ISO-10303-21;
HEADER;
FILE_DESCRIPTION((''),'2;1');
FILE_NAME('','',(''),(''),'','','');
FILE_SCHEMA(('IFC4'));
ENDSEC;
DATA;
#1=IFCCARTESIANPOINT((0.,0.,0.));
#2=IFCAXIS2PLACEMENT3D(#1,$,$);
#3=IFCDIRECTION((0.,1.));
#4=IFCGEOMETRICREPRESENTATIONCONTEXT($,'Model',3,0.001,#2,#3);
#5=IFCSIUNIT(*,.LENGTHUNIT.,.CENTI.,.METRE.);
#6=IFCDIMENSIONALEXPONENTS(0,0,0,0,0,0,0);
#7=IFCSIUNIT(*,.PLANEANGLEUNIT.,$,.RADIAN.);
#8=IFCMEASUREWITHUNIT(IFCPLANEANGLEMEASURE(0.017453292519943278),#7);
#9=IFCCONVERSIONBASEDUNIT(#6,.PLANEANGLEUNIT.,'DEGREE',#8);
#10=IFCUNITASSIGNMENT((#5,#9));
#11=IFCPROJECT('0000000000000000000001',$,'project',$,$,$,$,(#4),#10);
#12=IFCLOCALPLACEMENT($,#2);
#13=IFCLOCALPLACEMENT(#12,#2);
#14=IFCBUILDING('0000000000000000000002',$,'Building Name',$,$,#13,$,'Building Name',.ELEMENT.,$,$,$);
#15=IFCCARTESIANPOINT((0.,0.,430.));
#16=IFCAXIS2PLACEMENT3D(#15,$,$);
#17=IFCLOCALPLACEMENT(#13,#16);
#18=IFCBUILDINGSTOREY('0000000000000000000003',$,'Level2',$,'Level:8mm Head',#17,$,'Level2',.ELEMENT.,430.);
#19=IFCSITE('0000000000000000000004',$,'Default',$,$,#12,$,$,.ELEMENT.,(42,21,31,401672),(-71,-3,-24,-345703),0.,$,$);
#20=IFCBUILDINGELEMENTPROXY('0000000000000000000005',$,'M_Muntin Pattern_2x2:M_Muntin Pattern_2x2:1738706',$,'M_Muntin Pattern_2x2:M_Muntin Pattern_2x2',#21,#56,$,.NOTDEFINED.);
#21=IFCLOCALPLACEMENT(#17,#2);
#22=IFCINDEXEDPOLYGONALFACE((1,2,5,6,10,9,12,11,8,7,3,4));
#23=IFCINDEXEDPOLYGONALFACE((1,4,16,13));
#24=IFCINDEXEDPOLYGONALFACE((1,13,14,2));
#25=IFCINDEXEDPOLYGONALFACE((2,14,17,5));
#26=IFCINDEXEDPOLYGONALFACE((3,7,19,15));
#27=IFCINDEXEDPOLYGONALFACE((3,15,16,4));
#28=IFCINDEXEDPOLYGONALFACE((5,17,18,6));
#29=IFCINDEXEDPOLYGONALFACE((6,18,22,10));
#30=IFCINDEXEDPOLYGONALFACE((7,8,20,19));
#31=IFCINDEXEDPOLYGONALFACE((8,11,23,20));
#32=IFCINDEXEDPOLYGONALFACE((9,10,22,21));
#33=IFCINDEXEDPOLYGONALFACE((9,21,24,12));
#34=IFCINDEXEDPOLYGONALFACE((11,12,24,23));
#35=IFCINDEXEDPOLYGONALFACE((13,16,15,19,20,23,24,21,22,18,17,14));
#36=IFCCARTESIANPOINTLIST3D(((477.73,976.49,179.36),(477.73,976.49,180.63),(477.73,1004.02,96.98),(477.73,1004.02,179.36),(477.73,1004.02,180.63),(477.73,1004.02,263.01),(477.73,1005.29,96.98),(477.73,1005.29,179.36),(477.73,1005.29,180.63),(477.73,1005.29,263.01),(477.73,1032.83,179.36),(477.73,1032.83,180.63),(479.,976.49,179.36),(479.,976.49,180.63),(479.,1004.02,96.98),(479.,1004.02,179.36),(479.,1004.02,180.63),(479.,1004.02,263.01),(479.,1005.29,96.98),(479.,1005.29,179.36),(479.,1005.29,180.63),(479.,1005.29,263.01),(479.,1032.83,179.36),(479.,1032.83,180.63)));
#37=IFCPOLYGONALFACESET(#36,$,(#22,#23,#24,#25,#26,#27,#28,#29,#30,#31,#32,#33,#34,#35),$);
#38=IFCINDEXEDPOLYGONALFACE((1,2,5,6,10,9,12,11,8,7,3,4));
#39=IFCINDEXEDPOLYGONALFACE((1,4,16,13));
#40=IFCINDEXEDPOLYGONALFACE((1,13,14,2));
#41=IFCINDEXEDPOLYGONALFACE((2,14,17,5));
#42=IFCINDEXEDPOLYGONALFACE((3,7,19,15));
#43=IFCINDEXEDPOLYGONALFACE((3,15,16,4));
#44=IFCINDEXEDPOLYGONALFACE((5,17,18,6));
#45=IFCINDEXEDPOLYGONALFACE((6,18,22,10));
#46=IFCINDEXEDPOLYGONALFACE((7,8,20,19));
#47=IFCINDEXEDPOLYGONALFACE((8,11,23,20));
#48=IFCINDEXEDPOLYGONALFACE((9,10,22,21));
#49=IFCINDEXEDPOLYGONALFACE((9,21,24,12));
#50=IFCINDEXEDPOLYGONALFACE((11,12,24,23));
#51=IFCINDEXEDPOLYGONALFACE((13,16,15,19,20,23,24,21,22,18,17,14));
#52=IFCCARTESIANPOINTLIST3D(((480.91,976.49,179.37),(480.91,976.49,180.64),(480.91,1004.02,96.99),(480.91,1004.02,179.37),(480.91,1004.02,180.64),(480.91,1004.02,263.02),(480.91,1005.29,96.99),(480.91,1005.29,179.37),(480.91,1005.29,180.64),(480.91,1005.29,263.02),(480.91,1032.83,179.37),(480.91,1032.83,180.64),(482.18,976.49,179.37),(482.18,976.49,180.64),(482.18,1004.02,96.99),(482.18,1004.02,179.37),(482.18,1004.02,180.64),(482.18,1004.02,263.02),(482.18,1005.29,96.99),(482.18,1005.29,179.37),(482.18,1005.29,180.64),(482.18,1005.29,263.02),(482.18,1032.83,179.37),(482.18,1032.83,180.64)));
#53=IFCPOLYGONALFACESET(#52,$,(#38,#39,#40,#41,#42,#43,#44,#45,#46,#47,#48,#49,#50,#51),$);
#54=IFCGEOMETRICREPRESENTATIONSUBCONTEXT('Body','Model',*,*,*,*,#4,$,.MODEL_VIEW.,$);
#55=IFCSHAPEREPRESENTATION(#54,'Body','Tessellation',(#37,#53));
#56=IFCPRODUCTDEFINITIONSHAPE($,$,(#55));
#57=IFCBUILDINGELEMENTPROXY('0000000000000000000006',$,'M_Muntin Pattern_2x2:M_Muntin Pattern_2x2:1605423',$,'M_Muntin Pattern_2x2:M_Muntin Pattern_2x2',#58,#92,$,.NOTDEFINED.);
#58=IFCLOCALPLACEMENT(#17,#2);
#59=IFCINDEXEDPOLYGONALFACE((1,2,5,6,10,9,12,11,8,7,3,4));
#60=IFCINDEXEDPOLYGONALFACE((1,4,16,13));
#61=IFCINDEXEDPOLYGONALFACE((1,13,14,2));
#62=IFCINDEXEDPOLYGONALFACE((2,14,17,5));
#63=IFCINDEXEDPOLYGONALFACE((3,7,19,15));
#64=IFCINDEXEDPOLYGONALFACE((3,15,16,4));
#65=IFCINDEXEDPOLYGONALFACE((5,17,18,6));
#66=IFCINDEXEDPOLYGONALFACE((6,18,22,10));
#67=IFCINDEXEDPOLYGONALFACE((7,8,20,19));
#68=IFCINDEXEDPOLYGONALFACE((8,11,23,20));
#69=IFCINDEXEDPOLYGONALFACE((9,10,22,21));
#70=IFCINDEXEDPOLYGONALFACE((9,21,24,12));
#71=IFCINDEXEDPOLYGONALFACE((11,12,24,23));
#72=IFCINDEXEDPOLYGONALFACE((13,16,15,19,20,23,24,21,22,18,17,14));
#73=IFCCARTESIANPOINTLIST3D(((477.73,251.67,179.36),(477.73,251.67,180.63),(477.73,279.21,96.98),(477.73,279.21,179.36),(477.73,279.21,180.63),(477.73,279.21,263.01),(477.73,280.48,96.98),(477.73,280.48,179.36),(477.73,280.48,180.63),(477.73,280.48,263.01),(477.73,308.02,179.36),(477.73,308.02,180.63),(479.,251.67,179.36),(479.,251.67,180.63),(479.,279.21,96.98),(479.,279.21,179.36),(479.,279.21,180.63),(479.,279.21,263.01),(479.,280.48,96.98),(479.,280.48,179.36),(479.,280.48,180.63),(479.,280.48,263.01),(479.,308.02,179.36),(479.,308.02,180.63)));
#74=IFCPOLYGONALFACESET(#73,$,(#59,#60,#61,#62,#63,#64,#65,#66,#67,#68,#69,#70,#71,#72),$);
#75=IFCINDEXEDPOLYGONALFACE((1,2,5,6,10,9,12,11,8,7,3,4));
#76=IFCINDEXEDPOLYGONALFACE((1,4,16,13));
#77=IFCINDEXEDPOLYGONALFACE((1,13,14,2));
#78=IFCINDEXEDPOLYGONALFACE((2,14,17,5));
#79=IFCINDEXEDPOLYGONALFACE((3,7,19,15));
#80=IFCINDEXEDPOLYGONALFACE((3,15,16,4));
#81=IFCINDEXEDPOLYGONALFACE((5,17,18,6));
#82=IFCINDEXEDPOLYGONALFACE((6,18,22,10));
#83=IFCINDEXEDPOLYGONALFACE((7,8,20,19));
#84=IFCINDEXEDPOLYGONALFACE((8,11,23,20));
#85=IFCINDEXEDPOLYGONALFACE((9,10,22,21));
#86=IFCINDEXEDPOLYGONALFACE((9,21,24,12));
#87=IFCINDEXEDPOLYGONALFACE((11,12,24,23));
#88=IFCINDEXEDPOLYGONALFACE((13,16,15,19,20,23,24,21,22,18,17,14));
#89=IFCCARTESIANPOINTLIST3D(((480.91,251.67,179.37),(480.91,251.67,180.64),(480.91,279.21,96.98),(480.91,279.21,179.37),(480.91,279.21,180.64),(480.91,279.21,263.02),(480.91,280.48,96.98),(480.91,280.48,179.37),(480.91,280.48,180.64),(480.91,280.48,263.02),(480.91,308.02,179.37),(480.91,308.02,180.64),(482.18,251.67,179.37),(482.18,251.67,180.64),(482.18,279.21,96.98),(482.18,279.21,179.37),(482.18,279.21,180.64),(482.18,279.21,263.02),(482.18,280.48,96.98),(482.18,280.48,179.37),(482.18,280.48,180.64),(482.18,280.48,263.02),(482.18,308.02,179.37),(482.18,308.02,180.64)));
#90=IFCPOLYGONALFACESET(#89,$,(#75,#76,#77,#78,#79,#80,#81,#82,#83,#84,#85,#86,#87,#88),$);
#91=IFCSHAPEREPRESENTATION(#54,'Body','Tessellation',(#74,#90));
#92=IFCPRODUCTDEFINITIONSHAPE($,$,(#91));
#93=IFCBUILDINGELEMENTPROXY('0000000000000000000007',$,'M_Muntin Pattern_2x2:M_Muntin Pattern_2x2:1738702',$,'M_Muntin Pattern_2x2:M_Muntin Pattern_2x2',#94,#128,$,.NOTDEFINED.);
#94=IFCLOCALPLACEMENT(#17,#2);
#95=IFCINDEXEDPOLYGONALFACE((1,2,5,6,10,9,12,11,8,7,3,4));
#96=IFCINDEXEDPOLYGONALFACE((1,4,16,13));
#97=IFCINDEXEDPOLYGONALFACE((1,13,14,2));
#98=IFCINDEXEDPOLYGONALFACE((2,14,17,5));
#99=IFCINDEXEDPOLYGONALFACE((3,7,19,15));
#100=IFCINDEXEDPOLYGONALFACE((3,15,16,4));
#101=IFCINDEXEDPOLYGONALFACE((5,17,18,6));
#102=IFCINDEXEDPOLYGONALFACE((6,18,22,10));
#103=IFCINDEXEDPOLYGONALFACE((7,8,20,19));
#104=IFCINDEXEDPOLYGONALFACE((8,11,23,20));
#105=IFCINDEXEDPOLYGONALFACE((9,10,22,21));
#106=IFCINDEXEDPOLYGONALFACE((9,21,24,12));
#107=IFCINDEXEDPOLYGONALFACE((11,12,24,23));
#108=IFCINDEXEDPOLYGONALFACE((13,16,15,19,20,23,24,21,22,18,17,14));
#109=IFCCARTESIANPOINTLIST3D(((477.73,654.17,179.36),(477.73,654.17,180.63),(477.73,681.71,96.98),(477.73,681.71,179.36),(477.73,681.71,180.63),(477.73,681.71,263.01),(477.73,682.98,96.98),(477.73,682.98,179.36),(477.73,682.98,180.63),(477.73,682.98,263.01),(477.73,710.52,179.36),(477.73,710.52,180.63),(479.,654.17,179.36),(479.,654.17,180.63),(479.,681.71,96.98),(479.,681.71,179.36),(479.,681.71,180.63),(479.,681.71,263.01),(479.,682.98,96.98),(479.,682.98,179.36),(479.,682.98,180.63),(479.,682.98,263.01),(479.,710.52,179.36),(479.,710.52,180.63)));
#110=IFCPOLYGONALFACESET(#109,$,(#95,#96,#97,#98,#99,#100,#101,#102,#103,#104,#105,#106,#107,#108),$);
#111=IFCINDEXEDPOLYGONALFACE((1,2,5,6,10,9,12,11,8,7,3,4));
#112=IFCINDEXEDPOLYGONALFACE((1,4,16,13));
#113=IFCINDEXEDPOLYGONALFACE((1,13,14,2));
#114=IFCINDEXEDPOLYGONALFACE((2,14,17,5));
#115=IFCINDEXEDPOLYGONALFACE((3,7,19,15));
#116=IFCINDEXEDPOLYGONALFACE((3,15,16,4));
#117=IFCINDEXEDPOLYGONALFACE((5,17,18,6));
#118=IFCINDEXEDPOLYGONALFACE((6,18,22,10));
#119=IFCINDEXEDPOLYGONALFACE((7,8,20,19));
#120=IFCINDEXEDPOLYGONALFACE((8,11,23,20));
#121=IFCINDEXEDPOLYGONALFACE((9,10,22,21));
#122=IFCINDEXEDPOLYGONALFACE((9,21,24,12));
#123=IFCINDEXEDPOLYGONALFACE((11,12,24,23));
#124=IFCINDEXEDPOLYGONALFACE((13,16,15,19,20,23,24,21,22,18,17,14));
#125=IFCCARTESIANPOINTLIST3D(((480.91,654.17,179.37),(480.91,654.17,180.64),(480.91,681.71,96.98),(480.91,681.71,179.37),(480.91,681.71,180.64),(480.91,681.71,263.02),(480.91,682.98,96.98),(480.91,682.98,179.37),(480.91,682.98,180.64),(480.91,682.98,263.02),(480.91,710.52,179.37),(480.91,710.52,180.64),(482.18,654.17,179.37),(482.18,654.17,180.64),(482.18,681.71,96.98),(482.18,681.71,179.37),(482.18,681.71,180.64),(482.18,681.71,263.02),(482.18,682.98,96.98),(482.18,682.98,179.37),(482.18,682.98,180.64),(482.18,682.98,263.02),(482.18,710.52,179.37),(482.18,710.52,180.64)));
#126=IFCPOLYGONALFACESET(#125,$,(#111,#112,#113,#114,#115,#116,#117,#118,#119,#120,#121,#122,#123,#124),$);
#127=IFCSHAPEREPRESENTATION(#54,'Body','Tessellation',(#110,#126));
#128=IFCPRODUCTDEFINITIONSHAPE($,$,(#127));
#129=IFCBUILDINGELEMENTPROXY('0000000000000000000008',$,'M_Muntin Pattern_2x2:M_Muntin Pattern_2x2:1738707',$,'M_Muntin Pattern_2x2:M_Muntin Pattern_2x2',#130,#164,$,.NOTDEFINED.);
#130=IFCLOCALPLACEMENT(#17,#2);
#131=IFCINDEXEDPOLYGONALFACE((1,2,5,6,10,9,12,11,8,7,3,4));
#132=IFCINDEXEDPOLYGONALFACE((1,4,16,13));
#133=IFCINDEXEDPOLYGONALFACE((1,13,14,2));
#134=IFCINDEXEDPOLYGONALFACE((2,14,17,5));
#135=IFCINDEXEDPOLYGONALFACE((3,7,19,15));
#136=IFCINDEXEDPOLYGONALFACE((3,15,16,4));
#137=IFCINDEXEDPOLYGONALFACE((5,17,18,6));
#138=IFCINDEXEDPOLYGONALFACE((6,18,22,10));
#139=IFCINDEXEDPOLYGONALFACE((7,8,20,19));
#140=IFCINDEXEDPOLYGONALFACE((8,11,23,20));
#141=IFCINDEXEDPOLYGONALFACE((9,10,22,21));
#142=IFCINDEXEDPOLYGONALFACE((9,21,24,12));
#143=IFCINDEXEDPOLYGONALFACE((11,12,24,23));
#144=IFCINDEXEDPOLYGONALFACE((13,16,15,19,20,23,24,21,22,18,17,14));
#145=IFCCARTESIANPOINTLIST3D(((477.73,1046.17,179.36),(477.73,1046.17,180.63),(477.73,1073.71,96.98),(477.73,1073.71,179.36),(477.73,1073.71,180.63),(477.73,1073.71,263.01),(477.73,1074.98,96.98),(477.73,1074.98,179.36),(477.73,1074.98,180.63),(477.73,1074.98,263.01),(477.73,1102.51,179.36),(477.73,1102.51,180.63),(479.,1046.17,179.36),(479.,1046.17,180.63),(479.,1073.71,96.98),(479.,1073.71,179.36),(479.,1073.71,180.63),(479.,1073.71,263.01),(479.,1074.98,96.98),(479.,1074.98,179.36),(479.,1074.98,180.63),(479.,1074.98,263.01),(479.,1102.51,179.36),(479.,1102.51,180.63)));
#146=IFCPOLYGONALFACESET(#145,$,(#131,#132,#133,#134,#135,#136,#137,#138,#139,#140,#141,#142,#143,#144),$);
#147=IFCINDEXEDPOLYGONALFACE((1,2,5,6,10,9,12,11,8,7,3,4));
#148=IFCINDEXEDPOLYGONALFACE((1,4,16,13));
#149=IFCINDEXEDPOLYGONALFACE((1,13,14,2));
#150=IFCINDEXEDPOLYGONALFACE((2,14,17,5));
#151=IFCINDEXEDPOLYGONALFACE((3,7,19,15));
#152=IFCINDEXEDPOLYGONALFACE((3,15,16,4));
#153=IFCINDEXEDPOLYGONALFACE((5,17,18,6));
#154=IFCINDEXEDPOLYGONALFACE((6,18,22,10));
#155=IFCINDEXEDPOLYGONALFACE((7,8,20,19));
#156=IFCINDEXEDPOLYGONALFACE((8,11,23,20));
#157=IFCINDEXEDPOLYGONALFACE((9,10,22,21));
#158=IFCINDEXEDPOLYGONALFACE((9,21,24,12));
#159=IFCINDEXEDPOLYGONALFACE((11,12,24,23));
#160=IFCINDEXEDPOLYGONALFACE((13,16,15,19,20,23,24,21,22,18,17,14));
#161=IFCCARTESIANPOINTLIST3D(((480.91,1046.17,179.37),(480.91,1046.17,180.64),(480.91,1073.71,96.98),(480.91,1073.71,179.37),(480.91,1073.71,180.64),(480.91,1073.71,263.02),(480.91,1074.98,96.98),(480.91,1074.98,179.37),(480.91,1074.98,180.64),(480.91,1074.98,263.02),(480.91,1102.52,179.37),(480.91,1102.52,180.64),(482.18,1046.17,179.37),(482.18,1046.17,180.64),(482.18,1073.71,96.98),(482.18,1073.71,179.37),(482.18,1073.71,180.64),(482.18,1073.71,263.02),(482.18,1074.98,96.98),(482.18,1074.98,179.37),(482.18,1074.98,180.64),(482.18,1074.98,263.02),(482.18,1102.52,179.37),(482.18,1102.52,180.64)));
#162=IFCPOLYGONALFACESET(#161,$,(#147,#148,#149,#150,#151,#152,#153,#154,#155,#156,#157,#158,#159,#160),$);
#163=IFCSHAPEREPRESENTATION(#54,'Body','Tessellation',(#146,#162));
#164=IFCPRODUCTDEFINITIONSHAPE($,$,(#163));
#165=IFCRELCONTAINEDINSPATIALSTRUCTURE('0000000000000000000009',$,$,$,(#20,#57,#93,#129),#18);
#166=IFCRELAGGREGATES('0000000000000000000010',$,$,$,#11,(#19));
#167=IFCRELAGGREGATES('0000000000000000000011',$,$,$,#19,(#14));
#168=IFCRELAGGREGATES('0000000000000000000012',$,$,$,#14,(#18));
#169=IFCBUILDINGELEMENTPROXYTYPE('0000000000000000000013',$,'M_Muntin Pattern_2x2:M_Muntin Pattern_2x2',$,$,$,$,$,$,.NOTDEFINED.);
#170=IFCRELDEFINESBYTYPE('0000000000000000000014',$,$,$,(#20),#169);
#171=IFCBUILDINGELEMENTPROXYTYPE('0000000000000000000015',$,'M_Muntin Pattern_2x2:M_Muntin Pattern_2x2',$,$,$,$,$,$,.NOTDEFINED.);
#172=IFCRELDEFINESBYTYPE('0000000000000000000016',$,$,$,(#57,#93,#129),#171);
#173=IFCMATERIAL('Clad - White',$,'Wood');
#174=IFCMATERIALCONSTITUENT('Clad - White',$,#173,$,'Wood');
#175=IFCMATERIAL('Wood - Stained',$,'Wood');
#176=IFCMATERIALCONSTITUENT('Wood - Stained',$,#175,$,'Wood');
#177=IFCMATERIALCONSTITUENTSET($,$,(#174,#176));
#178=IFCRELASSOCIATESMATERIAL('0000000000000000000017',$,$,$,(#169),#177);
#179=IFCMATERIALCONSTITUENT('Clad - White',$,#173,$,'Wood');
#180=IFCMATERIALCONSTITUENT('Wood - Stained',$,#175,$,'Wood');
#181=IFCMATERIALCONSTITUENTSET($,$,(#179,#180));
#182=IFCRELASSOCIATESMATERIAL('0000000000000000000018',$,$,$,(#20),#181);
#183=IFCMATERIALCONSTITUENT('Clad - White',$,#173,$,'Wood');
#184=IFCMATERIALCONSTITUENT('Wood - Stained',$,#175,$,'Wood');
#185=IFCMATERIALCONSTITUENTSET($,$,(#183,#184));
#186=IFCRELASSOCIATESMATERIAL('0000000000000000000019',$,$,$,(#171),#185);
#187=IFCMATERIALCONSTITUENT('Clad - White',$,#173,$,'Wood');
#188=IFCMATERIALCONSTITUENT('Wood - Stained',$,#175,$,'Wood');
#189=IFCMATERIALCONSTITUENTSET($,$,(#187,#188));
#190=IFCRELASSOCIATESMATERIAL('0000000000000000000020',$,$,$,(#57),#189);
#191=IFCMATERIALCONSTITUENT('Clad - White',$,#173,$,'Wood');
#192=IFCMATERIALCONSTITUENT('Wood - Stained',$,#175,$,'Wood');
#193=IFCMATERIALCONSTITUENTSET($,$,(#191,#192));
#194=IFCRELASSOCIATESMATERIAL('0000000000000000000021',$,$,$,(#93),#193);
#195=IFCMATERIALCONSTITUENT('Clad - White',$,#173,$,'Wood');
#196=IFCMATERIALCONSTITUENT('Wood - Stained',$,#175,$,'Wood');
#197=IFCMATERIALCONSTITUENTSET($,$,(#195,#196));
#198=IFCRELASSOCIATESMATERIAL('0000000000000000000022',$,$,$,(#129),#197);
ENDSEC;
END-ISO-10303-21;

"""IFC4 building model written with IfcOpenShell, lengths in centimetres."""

from ifc_helpers import new_model, entity, si_unit, converted_unit, direction, frame, origin, place, context, subcontext, project, spatial, indexed_curve, outline, extrude, source, transform, mapped, material, constituent, constituent_set, type_object, type_shapes, element, save


model = new_model("IFC4")

# Units and contexts
model_context = context("Model", 3, precision=0.001, world=origin(), true_north=direction((0.0, 1.0)))
body_context = subcontext(model_context, "Body", "Model", "MODEL_VIEW")
ifc_project = project(units=[si_unit("LENGTHUNIT", "METRE", prefix="CENTI"), converted_unit("PLANEANGLEUNIT", "DEGREE", entity("IfcPlaneAngleMeasure", 0.017453292519943278), si_unit("PLANEANGLEUNIT", "RADIAN"), dimensions=[0, 0, 0, 0, 0, 0, 0])], contexts=[model_context])

# Site, building, storey
site_placement = place(None, origin())
site = spatial("IfcSite", under=ifc_project, at=site_placement, Name="Default", CompositionType="ELEMENT", RefLatitude=(42, 21, 31, 401672), RefLongitude=(-71, -3, -24, -345703), RefElevation=0.0)
building_placement = place(site_placement, origin())
building = spatial("IfcBuilding", under=site, at=building_placement, Name="Building Name", LongName="Building Name", CompositionType="ELEMENT")
storey_placement = place(building_placement, frame((0.0, 0.0, 430.0)))
storey = spatial("IfcBuildingStorey", under=building, at=storey_placement, Name="Level2", ObjectType="Level:8mm Head", LongName="Level2", CompositionType="ELEMENT", Elevation=430.0)

# Building element proxies
ifc_material_1 = material(Name="Clad - White", Category="Wood")
ifc_material_2 = material(Name="Wood - Stained", Category="Wood")
ifc_constituent_1 = constituent(ifc_material_1, Name="Clad - White", Category="Wood")
ifc_constituent_2 = constituent(ifc_material_2, Name="Wood - Stained", Category="Wood")
ifc_constituent_set_1 = constituent_set(constituents=[ifc_constituent_1, ifc_constituent_2])
building_element_proxy_type_1 = type_object("IfcBuildingElementProxyType", Name="M_Muntin Pattern_2x2:M_Muntin Pattern_2x2", PredefinedType="NOTDEFINED", material=ifc_constituent_set_1)
shared_shape_1 = source(origin(), body_context, "Body", "SweptSolid", [
    extrude(outline(indexed_curve([(0.64, -0.64), (83.01, -0.64), (83.01, 0.63), (0.64, 0.63), (0.64, 28.17), (-0.63, 28.17), (-0.63, 0.63), (-83.02, 0.63), (-83.02, -0.64), (-0.63, -0.64), (-0.63, -28.17), (0.64, -28.17), (0.64, -0.64)], self_intersect=False)), frame((0.0, 0.95, 83.01), z_axis=(0.0, 1.0, 0.0), x_axis=(0.0, 0.0, 1.0)), (0.0, 0.0, 1.0), 1.27),
    extrude(outline(indexed_curve([(0.64, -0.64), (83.02, -0.64), (83.02, 0.63), (0.64, 0.63), (0.64, 28.17), (-0.63, 28.17), (-0.63, 0.63), (-83.02, 0.63), (-83.02, -0.64), (-0.63, -0.64), (-0.63, -28.17), (0.64, -28.17), (0.64, -0.64)], self_intersect=False)), frame((0.0, -2.22, 83.02), z_axis=(0.0, 1.0, 0.0), x_axis=(0.0, 0.0, 1.0)), (0.0, 0.0, 1.0), 1.27),
])
type_shapes(building_element_proxy_type_1, [shared_shape_1])
ifc_constituent_3 = constituent(ifc_material_1, Name="Clad - White", Category="Wood")
ifc_constituent_4 = constituent(ifc_material_2, Name="Wood - Stained", Category="Wood")
ifc_constituent_set_2 = constituent_set(constituents=[ifc_constituent_3, ifc_constituent_4])
proxy_1_placement = place(storey_placement, frame((479.95, 1004.66, 96.99), z_axis=(0.0, 0.0, 1.0), x_axis=(0.0, 1.0, 0.0)))
element("IfcBuildingElementProxy", 1, at=proxy_1_placement, inside=storey, type_object=building_element_proxy_type_1, material=ifc_constituent_set_2, Name="M_Muntin Pattern_2x2:M_Muntin Pattern_2x2:1738706", ObjectType="M_Muntin Pattern_2x2:M_Muntin Pattern_2x2", PredefinedType="NOTDEFINED", context=body_context, shape_type="MappedRepresentation", body=[
    mapped(shared_shape_1, transform((0.0, 0.0, 0.0), scale=1.0)),
])
ifc_constituent_5 = constituent(ifc_material_1, Name="Clad - White", Category="Wood")
ifc_constituent_6 = constituent(ifc_material_2, Name="Wood - Stained", Category="Wood")
ifc_constituent_set_3 = constituent_set(constituents=[ifc_constituent_5, ifc_constituent_6])
ifc_constituent_7 = constituent(ifc_material_1, Name="Clad - White", Category="Wood")
ifc_constituent_8 = constituent(ifc_material_2, Name="Wood - Stained", Category="Wood")
ifc_constituent_set_4 = constituent_set(constituents=[ifc_constituent_7, ifc_constituent_8])
building_element_proxy_type_2 = type_object("IfcBuildingElementProxyType", Name="M_Muntin Pattern_2x2:M_Muntin Pattern_2x2", PredefinedType="NOTDEFINED", material=ifc_constituent_set_4)
shared_shape_2 = source(origin(), body_context, "Body", "SweptSolid", [
    extrude(outline(indexed_curve([(0.64, -0.64), (83.01, -0.64), (83.01, 0.63), (0.64, 0.63), (0.64, 28.17), (-0.63, 28.17), (-0.63, 0.63), (-83.02, 0.63), (-83.02, -0.64), (-0.63, -0.64), (-0.63, -28.17), (0.64, -28.17), (0.64, -0.64)], self_intersect=False)), frame((0.0, -2.22, 83.01), z_axis=(0.0, 1.0, 0.0), x_axis=(0.0, 0.0, 1.0)), (0.0, 0.0, 1.0), 1.27),
    extrude(outline(indexed_curve([(0.64, -0.64), (83.02, -0.64), (83.02, 0.63), (0.64, 0.63), (0.64, 28.17), (-0.63, 28.17), (-0.63, 0.63), (-83.02, 0.63), (-83.02, -0.64), (-0.63, -0.64), (-0.63, -28.17), (0.64, -28.17), (0.64, -0.64)], self_intersect=False)), frame((0.0, 0.95, 83.02), z_axis=(0.0, 1.0, 0.0), x_axis=(0.0, 0.0, 1.0)), (0.0, 0.0, 1.0), 1.27),
])
type_shapes(building_element_proxy_type_2, [shared_shape_2])
proxy_2_placement = place(storey_placement, frame((479.95, 279.84, 96.98), z_axis=(0.0, 0.0, 1.0), x_axis=(0.0, -1.0, 0.0)))
element("IfcBuildingElementProxy", 2, at=proxy_2_placement, inside=storey, type_object=building_element_proxy_type_2, material=ifc_constituent_set_3, Name="M_Muntin Pattern_2x2:M_Muntin Pattern_2x2:1605423", ObjectType="M_Muntin Pattern_2x2:M_Muntin Pattern_2x2", PredefinedType="NOTDEFINED", context=body_context, shape_type="MappedRepresentation", body=[
    mapped(shared_shape_2, transform((0.0, 0.0, 0.0), scale=1.0)),
])
ifc_constituent_9 = constituent(ifc_material_1, Name="Clad - White", Category="Wood")
ifc_constituent_10 = constituent(ifc_material_2, Name="Wood - Stained", Category="Wood")
ifc_constituent_set_5 = constituent_set(constituents=[ifc_constituent_9, ifc_constituent_10])
proxy_3_placement = place(storey_placement, frame((479.95, 682.34, 96.98), z_axis=(0.0, 0.0, 1.0), x_axis=(0.0, -1.0, 0.0)))
element("IfcBuildingElementProxy", 3, at=proxy_3_placement, inside=storey, type_object=building_element_proxy_type_2, material=ifc_constituent_set_5, Name="M_Muntin Pattern_2x2:M_Muntin Pattern_2x2:1738702", ObjectType="M_Muntin Pattern_2x2:M_Muntin Pattern_2x2", PredefinedType="NOTDEFINED", context=body_context, shape_type="MappedRepresentation", body=[
    mapped(shared_shape_2, transform((0.0, 0.0, 0.0), scale=1.0)),
])
ifc_constituent_11 = constituent(ifc_material_1, Name="Clad - White", Category="Wood")
ifc_constituent_12 = constituent(ifc_material_2, Name="Wood - Stained", Category="Wood")
ifc_constituent_set_6 = constituent_set(constituents=[ifc_constituent_11, ifc_constituent_12])
proxy_4_placement = place(storey_placement, frame((479.95, 1074.34, 96.98), z_axis=(0.0, 0.0, 1.0), x_axis=(0.0, -1.0, 0.0)))
element("IfcBuildingElementProxy", 4, at=proxy_4_placement, inside=storey, type_object=building_element_proxy_type_2, material=ifc_constituent_set_6, Name="M_Muntin Pattern_2x2:M_Muntin Pattern_2x2:1738707", ObjectType="M_Muntin Pattern_2x2:M_Muntin Pattern_2x2", PredefinedType="NOTDEFINED", context=body_context, shape_type="MappedRepresentation", body=[
    mapped(shared_shape_2, transform((0.0, 0.0, 0.0), scale=1.0)),
])

save(model, "model.ifc")
